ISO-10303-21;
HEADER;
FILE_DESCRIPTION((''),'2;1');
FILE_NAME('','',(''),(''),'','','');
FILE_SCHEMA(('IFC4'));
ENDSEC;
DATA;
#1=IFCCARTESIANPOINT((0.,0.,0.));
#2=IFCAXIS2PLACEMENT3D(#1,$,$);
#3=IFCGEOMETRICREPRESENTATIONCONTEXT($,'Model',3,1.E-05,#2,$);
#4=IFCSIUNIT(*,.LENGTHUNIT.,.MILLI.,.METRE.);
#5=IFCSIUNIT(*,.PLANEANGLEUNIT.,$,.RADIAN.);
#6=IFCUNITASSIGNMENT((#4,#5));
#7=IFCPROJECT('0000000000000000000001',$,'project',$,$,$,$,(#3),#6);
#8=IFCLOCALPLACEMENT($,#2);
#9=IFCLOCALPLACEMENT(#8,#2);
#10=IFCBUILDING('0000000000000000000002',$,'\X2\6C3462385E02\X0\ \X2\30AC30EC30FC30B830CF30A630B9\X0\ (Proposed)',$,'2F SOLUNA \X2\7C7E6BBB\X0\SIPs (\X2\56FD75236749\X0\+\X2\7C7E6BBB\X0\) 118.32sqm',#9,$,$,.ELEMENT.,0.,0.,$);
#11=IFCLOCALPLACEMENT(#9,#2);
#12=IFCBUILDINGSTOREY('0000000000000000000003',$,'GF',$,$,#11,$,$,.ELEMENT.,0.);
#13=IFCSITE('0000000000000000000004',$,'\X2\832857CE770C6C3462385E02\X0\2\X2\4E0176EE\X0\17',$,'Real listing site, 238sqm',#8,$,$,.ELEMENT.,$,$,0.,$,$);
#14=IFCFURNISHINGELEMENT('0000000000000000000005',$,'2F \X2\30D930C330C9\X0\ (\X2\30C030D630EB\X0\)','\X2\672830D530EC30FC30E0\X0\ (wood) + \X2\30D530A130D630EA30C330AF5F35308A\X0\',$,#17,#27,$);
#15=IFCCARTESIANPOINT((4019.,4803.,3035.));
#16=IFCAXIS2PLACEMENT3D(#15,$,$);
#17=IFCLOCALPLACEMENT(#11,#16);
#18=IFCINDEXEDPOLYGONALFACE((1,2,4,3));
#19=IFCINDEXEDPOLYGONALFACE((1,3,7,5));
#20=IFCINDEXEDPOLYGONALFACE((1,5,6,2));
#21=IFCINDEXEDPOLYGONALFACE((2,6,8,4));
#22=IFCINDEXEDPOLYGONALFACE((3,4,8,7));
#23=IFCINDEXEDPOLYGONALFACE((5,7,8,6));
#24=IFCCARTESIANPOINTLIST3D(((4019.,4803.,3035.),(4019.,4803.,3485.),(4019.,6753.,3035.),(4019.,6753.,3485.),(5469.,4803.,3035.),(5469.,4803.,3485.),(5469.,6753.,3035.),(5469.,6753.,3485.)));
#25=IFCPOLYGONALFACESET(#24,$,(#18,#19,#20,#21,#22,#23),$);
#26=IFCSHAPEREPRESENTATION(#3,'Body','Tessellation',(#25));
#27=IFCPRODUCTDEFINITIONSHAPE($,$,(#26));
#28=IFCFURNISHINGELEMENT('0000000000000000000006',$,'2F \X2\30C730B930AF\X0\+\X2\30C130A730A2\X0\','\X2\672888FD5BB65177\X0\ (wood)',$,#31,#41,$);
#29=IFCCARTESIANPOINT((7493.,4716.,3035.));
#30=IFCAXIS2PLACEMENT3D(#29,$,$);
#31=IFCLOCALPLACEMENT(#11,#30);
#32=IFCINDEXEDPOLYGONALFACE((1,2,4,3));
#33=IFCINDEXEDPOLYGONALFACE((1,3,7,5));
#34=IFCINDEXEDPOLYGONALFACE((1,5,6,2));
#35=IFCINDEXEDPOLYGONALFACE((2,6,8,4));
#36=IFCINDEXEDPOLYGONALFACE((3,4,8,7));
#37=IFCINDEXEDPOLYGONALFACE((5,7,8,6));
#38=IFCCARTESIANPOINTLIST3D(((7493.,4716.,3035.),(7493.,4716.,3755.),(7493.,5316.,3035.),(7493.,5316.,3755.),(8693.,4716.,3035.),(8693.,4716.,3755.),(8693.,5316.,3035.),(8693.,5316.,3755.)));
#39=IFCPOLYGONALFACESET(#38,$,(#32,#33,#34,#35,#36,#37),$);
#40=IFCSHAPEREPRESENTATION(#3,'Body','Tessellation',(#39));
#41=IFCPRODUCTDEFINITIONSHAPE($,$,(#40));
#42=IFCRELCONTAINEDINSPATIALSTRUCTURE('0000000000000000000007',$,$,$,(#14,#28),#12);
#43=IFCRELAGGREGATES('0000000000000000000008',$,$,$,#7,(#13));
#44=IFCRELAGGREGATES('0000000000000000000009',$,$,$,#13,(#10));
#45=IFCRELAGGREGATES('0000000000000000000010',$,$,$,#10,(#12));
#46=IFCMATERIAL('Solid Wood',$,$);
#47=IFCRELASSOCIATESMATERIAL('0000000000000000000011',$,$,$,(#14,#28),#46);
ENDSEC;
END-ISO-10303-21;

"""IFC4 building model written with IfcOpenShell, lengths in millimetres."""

from ifc_helpers import new_model, si_unit, frame, frame_2d, origin, place, context, project, spatial, rectangle, extrude, material, element, save


model = new_model("IFC4")

# Units and contexts
model_context = context("Model", 3, precision=1e-05, world=origin())
ifc_project = project(units=[si_unit("LENGTHUNIT", "METRE", prefix="MILLI"), si_unit("PLANEANGLEUNIT", "RADIAN")], contexts=[model_context])

# Site, building, storey
site_placement = place(None, origin())
site = spatial("IfcSite", under=ifc_project, at=site_placement, Name="茨城県水戸市2丁目17", ObjectType="Real listing site, 238sqm", CompositionType="ELEMENT", RefElevation=0.0)
building_placement = place(site_placement, origin())
building = spatial("IfcBuilding", under=site, at=building_placement, Name="水戸市 ガレージハウス (Proposed)", ObjectType="2F SOLUNA 籾殻SIPs (国産杉+籾殻) 118.32sqm", CompositionType="ELEMENT", ElevationOfRefHeight=0.0, ElevationOfTerrain=0.0)
storey_placement = place(building_placement, origin())
storey = spatial("IfcBuildingStorey", under=building, at=storey_placement, Name="GF", CompositionType="ELEMENT", Elevation=0.0)

# Shared definitions
ifc_material_1 = material(Name="Solid Wood")

# Furnishing elements
furnishing_1_placement = place(storey_placement, frame((4019.0, 4803.0, 3035.0)))
element("IfcFurnishingElement", 1, at=furnishing_1_placement, inside=storey, material=ifc_material_1, Name="2F ベッド (ダブル)", Description="木フレーム (wood) + ファブリック張り", context=model_context, shape_type="SweptSolid", body=[
    extrude(rectangle(XDim=1450.0, YDim=1950.0, at=frame_2d((725.0, 975.0))), frame((4019.0, 4803.0, 3035.0)), (0.0, 0.0, 1.0), 450.0),
])
furnishing_2_placement = place(storey_placement, frame((7493.0, 4716.0, 3035.0)))
element("IfcFurnishingElement", 2, at=furnishing_2_placement, inside=storey, material=ifc_material_1, Name="2F デスク+チェア", Description="木製家具 (wood)", context=model_context, shape_type="SweptSolid", body=[
    extrude(rectangle(XDim=1200.0, YDim=600.0, at=frame_2d((600.0, 300.0))), frame((7493.0, 4716.0, 3035.0)), (0.0, 0.0, 1.0), 720.0),
])

save(model, "model.ifc")
